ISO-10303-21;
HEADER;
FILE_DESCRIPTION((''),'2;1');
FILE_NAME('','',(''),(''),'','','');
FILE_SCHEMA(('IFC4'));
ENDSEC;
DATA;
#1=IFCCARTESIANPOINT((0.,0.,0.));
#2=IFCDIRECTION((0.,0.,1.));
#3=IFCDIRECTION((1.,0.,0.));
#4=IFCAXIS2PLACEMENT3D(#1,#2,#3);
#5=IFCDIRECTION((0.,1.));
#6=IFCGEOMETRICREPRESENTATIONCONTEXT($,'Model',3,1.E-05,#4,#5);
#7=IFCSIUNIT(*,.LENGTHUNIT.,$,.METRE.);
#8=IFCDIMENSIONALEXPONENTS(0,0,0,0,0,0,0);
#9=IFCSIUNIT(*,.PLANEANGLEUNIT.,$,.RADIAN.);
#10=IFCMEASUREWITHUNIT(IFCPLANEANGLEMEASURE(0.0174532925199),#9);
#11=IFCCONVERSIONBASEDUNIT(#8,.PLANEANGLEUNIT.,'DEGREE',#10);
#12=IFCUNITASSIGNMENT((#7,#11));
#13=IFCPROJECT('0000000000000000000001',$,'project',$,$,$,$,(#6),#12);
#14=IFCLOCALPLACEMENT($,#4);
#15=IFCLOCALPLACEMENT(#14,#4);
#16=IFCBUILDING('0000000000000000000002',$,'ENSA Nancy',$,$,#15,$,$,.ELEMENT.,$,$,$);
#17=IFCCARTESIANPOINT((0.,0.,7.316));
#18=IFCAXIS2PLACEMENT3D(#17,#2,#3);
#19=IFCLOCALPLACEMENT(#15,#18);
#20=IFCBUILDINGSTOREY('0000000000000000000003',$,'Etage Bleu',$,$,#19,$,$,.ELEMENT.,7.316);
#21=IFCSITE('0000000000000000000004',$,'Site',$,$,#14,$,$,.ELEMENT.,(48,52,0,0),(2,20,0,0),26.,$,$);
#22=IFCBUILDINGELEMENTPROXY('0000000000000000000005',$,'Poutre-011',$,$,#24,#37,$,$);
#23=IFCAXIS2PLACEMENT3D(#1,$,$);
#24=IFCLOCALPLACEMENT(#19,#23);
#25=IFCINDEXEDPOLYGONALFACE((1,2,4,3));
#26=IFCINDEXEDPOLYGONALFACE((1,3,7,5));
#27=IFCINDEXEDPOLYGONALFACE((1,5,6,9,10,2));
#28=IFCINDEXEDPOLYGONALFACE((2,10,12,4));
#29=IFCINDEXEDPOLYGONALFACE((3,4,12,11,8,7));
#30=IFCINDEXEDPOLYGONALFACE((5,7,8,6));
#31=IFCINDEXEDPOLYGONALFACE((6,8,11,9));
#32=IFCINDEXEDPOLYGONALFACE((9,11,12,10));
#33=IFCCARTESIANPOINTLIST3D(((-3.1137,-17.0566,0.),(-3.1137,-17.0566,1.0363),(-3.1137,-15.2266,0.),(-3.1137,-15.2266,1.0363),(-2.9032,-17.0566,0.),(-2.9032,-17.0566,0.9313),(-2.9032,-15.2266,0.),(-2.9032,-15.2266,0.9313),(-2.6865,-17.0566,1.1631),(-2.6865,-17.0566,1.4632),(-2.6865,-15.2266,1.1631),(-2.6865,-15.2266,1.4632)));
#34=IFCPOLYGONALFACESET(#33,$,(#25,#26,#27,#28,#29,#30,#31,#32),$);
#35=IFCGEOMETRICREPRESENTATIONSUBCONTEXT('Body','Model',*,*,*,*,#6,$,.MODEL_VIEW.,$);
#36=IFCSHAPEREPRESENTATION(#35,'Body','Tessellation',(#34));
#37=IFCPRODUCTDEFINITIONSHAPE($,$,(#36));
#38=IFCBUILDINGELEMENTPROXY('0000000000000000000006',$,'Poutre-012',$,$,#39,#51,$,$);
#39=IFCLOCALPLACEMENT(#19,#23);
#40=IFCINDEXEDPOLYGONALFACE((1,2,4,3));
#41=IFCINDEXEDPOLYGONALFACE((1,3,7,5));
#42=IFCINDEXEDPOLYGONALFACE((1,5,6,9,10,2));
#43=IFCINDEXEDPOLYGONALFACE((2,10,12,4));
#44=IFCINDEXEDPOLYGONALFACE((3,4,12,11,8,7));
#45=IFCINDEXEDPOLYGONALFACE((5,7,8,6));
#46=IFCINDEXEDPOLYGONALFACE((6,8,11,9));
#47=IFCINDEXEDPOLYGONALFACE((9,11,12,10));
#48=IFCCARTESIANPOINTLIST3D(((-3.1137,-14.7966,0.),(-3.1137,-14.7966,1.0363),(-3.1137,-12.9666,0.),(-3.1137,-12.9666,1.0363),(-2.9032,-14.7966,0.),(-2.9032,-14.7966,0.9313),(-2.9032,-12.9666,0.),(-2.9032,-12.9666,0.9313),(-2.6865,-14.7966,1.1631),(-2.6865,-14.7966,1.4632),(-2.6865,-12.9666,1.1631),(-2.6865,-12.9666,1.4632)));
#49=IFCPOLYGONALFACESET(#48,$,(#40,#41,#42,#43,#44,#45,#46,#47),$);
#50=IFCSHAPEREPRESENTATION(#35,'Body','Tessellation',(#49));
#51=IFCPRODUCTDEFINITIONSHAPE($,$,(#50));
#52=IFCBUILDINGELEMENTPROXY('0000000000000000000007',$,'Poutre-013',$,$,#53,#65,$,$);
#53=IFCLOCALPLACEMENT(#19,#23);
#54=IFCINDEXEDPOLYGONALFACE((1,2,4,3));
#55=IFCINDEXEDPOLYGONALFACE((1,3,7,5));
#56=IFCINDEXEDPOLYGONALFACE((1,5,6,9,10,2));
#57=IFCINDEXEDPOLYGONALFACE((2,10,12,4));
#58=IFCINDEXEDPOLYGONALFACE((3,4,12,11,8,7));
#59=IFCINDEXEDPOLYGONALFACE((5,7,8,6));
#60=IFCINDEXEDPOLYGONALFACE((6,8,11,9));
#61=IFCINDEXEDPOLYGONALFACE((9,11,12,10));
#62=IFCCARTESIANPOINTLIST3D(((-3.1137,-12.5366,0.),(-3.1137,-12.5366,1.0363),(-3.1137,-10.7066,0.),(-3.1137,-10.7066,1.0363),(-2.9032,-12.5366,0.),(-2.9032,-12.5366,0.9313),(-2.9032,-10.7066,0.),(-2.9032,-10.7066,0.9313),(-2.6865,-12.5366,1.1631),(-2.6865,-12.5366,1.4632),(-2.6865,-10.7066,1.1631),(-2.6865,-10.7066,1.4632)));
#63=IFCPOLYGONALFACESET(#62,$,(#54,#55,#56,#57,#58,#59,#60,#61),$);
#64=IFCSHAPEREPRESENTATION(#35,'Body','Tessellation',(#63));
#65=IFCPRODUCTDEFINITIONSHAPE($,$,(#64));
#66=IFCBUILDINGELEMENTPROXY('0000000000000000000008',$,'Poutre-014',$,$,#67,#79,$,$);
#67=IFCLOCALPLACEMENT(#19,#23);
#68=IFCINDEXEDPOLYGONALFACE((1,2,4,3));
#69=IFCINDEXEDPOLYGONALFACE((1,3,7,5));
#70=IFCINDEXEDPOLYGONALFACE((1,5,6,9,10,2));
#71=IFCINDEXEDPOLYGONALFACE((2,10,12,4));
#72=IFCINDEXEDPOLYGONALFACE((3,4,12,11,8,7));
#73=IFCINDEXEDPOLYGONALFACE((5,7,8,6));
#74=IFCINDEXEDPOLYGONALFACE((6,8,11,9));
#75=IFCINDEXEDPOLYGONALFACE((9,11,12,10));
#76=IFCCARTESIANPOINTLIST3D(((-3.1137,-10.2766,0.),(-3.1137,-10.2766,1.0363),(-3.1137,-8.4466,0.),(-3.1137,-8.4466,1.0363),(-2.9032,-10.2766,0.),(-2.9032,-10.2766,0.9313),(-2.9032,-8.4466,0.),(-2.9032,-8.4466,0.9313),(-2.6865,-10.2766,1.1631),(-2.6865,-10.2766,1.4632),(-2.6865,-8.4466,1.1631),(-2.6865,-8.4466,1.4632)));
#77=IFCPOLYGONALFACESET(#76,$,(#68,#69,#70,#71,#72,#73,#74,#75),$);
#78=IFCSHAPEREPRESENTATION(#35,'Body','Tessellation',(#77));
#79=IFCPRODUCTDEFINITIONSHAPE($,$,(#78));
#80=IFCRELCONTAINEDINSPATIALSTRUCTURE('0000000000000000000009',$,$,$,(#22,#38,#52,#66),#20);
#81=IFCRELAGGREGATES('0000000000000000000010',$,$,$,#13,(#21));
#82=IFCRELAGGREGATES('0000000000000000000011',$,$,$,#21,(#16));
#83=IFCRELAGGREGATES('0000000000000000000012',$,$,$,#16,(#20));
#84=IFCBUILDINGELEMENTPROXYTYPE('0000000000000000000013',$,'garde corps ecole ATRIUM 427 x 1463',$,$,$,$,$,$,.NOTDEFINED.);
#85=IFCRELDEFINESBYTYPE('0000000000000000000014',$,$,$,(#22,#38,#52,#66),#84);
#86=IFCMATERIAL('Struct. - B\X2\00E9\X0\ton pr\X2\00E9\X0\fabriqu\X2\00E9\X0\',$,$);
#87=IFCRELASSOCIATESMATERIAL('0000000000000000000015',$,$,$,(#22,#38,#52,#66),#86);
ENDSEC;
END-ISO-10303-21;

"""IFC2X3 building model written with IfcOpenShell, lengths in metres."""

from ifc_helpers import new_model, entity, si_unit, converted_unit, direction, frame, origin_with_axes, place, context, subcontext, project, spatial, polyline, outline, extrude, material, type_object, element, save


model = new_model("IFC2X3")

# Units and contexts
model_context = context("Model", 3, precision=1e-05, world=origin_with_axes(), true_north=direction((0.0, 1.0)))
body_context = subcontext(model_context, "Body", "Model", "MODEL_VIEW")
ifc_project = project(units=[si_unit("LENGTHUNIT", "METRE"), converted_unit("PLANEANGLEUNIT", "DEGREE", entity("IfcPlaneAngleMeasure", 0.0174532925199), si_unit("PLANEANGLEUNIT", "RADIAN"), dimensions=[0, 0, 0, 0, 0, 0, 0])], contexts=[model_context])

# Site, building, storey
site_placement = place(None, origin_with_axes())
site = spatial("IfcSite", under=ifc_project, at=site_placement, Name="Site", CompositionType="ELEMENT", RefLatitude=(48, 52, 0, 0), RefLongitude=(2, 20, 0, 0), RefElevation=26.0)
building_placement = place(site_placement, origin_with_axes())
building = spatial("IfcBuilding", under=site, at=building_placement, Name="ENSA Nancy", CompositionType="ELEMENT")
storey_placement = place(building_placement, frame((0.0, 0.0, 7.316), z_axis=(0.0, 0.0, 1.0), x_axis=(1.0, 0.0, 0.0)))
storey = spatial("IfcBuildingStorey", under=building, at=storey_placement, Name="Etage Bleu", CompositionType="ELEMENT", Elevation=7.316)

# Building element proxies
ifc_material_1 = material(Name="Struct. - Béton préfabriqué")
building_element_proxy_type_1 = type_object("IfcBuildingElementProxyType", Name="garde corps ecole ATRIUM 427 x 1463", PredefinedType="NOTDEFINED")
proxy_1_placement = place(storey_placement, frame((-3.1137, -17.0566, 0.0), z_axis=(0.0, 0.0, 1.0), x_axis=(1.0, 0.0, 0.0)))
element("IfcBuildingElementProxy", 1, at=proxy_1_placement, inside=storey, type_object=building_element_proxy_type_1, material=ifc_material_1, Name="Poutre-011", context=body_context, shape_type="SweptSolid", body=[
    extrude(outline(polyline([(0.0, 1.0363), (0.0, 0.0), (0.2105, 0.0), (0.2105, 0.9313), (0.4272, 1.1631), (0.4272, 1.4632), (0.0, 1.0363)])), frame((0.0, 1.83, 0.0), z_axis=(0.0, -1.0, 0.0), x_axis=(1.0, 0.0, 0.0)), (0.0, 0.0, 1.0), 1.83),
])
proxy_2_placement = place(storey_placement, frame((-3.1137, -14.7966, 0.0), z_axis=(0.0, 0.0, 1.0), x_axis=(1.0, 0.0, 0.0)))
element("IfcBuildingElementProxy", 2, at=proxy_2_placement, inside=storey, type_object=building_element_proxy_type_1, material=ifc_material_1, Name="Poutre-012", context=body_context, shape_type="SweptSolid", body=[
    extrude(outline(polyline([(0.0, 1.0363), (0.0, 0.0), (0.2105, 0.0), (0.2105, 0.9313), (0.4272, 1.1631), (0.4272, 1.4632), (0.0, 1.0363)])), frame((0.0, 1.83, 0.0), z_axis=(0.0, -1.0, 0.0), x_axis=(1.0, 0.0, 0.0)), (0.0, 0.0, 1.0), 1.83),
])
proxy_3_placement = place(storey_placement, frame((-3.1137, -12.5366, 0.0), z_axis=(0.0, 0.0, 1.0), x_axis=(1.0, 0.0, 0.0)))
element("IfcBuildingElementProxy", 3, at=proxy_3_placement, inside=storey, type_object=building_element_proxy_type_1, material=ifc_material_1, Name="Poutre-013", context=body_context, shape_type="SweptSolid", body=[
    extrude(outline(polyline([(0.0, 1.0363), (0.0, 0.0), (0.2105, 0.0), (0.2105, 0.9313), (0.4272, 1.1631), (0.4272, 1.4632), (0.0, 1.0363)])), frame((0.0, 1.83, 0.0), z_axis=(0.0, -1.0, 0.0), x_axis=(1.0, 0.0, 0.0)), (0.0, 0.0, 1.0), 1.83),
])
proxy_4_placement = place(storey_placement, frame((-3.1137, -10.2766, 0.0), z_axis=(0.0, 0.0, 1.0), x_axis=(1.0, 0.0, 0.0)))
element("IfcBuildingElementProxy", 4, at=proxy_4_placement, inside=storey, type_object=building_element_proxy_type_1, material=ifc_material_1, Name="Poutre-014", context=body_context, shape_type="SweptSolid", body=[
    extrude(outline(polyline([(0.0, 1.0363), (0.0, 0.0), (0.2105, 0.0), (0.2105, 0.9313), (0.4272, 1.1631), (0.4272, 1.4632), (0.0, 1.0363)])), frame((0.0, 1.83, 0.0), z_axis=(0.0, -1.0, 0.0), x_axis=(1.0, 0.0, 0.0)), (0.0, 0.0, 1.0), 1.83),
])

save(model, "model.ifc")
